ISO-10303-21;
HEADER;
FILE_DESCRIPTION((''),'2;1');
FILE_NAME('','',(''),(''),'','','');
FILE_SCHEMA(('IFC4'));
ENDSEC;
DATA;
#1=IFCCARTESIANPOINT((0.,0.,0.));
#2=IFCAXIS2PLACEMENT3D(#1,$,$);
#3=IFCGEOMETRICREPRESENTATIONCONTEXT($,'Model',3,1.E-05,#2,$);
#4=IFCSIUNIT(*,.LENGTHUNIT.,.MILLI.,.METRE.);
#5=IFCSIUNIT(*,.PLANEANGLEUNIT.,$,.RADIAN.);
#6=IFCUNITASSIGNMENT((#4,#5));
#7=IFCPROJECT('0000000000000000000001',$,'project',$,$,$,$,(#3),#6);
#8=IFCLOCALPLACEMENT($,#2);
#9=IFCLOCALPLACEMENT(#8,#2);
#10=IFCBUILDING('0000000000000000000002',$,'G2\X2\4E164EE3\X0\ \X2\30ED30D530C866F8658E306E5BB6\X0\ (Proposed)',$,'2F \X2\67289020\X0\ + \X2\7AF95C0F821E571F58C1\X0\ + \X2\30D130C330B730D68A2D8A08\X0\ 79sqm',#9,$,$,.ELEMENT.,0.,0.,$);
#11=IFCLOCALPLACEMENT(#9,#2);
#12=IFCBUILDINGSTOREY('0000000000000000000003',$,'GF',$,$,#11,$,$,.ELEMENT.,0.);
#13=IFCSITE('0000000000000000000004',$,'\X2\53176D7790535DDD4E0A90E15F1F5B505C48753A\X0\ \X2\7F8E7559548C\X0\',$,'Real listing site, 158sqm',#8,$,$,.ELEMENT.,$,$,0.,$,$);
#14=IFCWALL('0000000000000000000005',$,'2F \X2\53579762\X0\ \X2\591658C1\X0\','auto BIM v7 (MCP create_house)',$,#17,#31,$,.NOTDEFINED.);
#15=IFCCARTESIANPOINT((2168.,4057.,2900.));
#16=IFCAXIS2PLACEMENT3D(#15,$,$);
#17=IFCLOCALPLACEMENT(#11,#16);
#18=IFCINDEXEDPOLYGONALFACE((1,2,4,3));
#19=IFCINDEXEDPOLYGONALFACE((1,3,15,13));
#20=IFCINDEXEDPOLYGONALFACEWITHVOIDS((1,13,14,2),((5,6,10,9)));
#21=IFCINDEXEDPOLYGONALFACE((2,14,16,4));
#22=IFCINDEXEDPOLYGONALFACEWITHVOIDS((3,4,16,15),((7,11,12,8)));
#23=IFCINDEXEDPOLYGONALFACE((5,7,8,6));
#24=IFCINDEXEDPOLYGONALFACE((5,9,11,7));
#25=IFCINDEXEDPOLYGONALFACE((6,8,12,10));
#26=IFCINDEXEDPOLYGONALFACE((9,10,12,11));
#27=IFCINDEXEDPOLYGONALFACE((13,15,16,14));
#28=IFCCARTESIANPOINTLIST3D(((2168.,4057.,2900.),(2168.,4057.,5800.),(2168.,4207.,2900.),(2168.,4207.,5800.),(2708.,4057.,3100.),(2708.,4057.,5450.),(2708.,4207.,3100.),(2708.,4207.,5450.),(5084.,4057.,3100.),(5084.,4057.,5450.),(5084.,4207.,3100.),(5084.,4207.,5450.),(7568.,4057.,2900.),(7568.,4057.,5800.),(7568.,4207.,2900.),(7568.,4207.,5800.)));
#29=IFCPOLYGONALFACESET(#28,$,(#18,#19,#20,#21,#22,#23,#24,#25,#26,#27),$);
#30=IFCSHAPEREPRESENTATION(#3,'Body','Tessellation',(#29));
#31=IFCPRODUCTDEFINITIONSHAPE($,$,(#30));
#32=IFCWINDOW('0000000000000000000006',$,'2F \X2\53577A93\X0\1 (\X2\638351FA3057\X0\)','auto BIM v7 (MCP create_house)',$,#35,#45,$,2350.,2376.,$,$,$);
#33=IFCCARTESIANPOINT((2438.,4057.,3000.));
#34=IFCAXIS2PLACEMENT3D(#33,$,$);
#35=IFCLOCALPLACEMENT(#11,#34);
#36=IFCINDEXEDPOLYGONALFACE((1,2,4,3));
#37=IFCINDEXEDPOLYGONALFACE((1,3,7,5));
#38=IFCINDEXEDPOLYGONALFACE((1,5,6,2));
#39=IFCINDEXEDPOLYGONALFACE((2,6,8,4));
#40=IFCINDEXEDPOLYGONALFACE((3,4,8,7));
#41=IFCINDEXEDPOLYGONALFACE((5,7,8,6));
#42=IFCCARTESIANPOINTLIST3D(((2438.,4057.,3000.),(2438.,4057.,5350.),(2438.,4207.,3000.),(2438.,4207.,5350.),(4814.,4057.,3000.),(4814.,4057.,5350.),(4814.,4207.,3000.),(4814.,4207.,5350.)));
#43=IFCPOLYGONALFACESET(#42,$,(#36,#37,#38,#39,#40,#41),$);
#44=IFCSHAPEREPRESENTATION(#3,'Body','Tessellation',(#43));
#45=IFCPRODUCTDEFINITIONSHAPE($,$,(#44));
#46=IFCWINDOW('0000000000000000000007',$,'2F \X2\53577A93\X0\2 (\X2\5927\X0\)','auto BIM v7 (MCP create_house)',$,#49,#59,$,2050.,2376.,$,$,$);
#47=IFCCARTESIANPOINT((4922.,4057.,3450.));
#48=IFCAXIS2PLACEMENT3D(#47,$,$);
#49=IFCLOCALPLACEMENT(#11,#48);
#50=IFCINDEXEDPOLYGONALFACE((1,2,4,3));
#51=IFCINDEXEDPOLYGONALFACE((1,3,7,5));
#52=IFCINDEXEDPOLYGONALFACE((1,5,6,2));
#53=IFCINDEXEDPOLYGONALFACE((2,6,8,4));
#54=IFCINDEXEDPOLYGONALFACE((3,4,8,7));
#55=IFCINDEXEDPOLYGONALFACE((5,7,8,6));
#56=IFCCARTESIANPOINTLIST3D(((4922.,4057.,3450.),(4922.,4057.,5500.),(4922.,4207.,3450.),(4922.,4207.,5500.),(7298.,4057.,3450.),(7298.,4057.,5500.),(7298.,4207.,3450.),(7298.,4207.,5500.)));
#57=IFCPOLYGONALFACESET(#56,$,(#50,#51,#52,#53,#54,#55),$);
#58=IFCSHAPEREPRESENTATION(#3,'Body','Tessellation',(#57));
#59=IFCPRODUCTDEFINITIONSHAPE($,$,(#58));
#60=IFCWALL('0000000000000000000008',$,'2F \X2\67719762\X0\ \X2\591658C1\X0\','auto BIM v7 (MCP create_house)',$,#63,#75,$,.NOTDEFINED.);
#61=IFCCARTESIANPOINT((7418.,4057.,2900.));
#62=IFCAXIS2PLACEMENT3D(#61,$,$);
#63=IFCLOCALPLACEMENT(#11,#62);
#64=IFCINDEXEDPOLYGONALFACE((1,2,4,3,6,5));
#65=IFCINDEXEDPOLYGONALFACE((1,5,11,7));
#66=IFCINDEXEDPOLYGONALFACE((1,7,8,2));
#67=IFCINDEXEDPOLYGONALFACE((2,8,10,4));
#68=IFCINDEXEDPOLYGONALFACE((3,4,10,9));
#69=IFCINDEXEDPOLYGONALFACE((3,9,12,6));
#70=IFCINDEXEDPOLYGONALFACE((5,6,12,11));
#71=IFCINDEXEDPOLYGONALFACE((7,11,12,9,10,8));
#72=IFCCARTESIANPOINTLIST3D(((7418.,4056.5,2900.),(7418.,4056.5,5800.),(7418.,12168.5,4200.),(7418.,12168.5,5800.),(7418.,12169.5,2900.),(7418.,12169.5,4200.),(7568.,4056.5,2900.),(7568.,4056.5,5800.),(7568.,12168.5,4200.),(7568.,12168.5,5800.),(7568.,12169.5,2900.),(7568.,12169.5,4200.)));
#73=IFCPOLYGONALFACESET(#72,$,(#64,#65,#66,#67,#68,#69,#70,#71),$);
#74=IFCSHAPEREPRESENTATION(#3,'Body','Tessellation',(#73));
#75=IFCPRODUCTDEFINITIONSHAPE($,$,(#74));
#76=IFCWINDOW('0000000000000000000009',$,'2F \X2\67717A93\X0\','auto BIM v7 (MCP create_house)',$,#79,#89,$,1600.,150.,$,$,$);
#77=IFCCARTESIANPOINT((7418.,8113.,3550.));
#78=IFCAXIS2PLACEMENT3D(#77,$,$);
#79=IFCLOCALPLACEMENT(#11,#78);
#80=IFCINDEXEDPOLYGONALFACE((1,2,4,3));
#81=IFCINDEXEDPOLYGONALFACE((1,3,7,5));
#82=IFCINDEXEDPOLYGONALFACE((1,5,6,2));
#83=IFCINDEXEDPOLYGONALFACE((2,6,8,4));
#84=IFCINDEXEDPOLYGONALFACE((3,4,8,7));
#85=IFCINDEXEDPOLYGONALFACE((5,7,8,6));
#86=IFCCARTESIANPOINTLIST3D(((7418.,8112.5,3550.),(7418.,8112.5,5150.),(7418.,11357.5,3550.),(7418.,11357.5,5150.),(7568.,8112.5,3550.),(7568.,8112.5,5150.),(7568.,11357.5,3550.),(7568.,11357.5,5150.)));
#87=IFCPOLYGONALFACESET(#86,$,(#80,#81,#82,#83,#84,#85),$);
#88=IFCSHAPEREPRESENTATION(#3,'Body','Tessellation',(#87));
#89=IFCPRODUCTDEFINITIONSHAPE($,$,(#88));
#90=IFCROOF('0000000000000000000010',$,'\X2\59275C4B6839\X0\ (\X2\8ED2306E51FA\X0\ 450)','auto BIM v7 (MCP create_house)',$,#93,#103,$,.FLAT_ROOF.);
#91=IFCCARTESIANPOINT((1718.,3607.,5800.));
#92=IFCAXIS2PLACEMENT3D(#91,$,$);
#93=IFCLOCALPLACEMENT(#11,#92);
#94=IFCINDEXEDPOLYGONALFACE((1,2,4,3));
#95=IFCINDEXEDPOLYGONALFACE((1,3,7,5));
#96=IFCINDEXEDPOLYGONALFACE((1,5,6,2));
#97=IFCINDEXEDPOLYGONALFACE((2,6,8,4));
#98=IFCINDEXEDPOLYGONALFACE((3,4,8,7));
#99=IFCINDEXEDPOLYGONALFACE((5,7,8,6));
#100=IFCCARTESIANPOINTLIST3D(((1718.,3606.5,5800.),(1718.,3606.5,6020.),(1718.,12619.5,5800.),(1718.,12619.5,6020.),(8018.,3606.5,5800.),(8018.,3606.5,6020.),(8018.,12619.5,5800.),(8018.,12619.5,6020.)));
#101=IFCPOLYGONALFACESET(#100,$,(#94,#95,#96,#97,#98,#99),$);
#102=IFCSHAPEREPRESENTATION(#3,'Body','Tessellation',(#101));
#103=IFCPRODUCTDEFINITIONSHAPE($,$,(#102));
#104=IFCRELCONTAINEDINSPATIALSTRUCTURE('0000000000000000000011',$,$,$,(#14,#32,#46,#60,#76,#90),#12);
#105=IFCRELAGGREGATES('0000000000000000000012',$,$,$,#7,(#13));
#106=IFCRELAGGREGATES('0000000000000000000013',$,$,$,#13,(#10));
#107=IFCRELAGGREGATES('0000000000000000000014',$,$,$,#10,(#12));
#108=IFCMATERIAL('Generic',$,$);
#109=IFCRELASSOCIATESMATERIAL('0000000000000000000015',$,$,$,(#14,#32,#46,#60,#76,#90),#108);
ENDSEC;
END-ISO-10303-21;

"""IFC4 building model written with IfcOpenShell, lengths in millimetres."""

from ifc_helpers import new_model, si_unit, frame, frame_2d, origin, place, context, project, spatial, rectangle, extrude, material, element, fill, save


model = new_model("IFC4")

# Units and contexts
model_context = context("Model", 3, precision=1e-05, world=origin())
ifc_project = project(units=[si_unit("LENGTHUNIT", "METRE", prefix="MILLI"), si_unit("PLANEANGLEUNIT", "RADIAN")], contexts=[model_context])

# Site, building, storey
site_placement = place(None, origin())
site = spatial("IfcSite", under=ifc_project, at=site_placement, Name="北海道川上郡弟子屈町 美留和", ObjectType="Real listing site, 158sqm", CompositionType="ELEMENT", RefElevation=0.0)
building_placement = place(site_placement, origin())
building = spatial("IfcBuilding", under=site, at=building_placement, Name="G2世代 ロフト書斎の家 (Proposed)", ObjectType="2F 木造 + 竹小舞土壁 + パッシブ設計 79sqm", CompositionType="ELEMENT", ElevationOfRefHeight=0.0, ElevationOfTerrain=0.0)
storey_placement = place(building_placement, origin())
storey = spatial("IfcBuildingStorey", under=building, at=storey_placement, Name="GF", CompositionType="ELEMENT", Elevation=0.0)

# Shared definitions
ifc_material = material(Name="Generic")

# Wall, openings, windows
wall_1_placement = place(storey_placement, frame((2168.0, 4057.0, 2900.0)))
wall_1 = element("IfcWall", 1, at=wall_1_placement, inside=storey, material=ifc_material, Name="2F 南面 外壁", Description="auto BIM v7 (MCP create_house)", PredefinedType="NOTDEFINED", context=model_context, shape_type="SweptSolid", body=[
    extrude(rectangle(XDim=5400.0, YDim=150.0, at=frame_2d((2700.0, 75.0))), frame((2168.0, 4057.0, 2900.0)), (0.0, 0.0, 1.0), 2900.0),
])
opening_1_placement = place(storey_placement, frame((2438.0, 4057.0, 3000.0)))
opening_1 = element("IfcOpeningElement", 2, at=opening_1_placement, cuts=wall_1, PredefinedType="NOTDEFINED", context=model_context, shape_type="SweptSolid", body=[
    extrude(rectangle(XDim=2376.0, YDim=150.0, at=frame_2d((1188.0, 75.0))), frame((2438.0, 4057.0, 3000.0)), (0.0, 0.0, 1.0), 2350.0),
])
opening_2_placement = place(storey_placement, frame((4922.0, 4057.0, 3450.0)))
opening_2 = element("IfcOpeningElement", 3, at=opening_2_placement, cuts=wall_1, PredefinedType="NOTDEFINED", context=model_context, shape_type="SweptSolid", body=[
    extrude(rectangle(XDim=2376.0, YDim=150.0, at=frame_2d((1188.0, 75.0))), frame((4922.0, 4057.0, 3450.0)), (0.0, 0.0, 1.0), 2050.0),
])
window_1_placement = place(storey_placement, frame((2438.0, 4057.0, 3000.0)))
window_1 = element("IfcWindow", 4, at=window_1_placement, inside=storey, material=ifc_material, Name="2F 南窓1 (掃出し)", Description="auto BIM v7 (MCP create_house)", OverallHeight=2350.0, OverallWidth=2376.0, context=model_context, shape_type="SweptSolid", body=[
    extrude(rectangle(XDim=2376.0, YDim=150.0, at=frame_2d((1188.0, 75.0))), frame((2438.0, 4057.0, 3000.0)), (0.0, 0.0, 1.0), 2350.0),
])
fill(opening_1, window_1)
window_2_placement = place(storey_placement, frame((4922.0, 4057.0, 3450.0)))
window_2 = element("IfcWindow", 5, at=window_2_placement, inside=storey, material=ifc_material, Name="2F 南窓2 (大)", Description="auto BIM v7 (MCP create_house)", OverallHeight=2050.0, OverallWidth=2376.0, context=model_context, shape_type="SweptSolid", body=[
    extrude(rectangle(XDim=2376.0, YDim=150.0, at=frame_2d((1188.0, 75.0))), frame((4922.0, 4057.0, 3450.0)), (0.0, 0.0, 1.0), 2050.0),
])
fill(opening_2, window_2)

# Wall, opening, window
wall_2_placement = place(storey_placement, frame((7418.0, 4057.0, 2900.0)))
wall_2 = element("IfcWall", 6, at=wall_2_placement, inside=storey, material=ifc_material, Name="2F 東面 外壁", Description="auto BIM v7 (MCP create_house)", PredefinedType="NOTDEFINED", context=model_context, shape_type="SweptSolid", body=[
    extrude(rectangle(XDim=150.0, YDim=8113.0, at=frame_2d((75.0, 4056.0))), frame((7418.0, 4057.0, 2900.0)), (0.0, 0.0, 1.0), 2900.0),
])
opening_3_placement = place(storey_placement, frame((7418.0, 8113.0, 3550.0)))
opening_3 = element("IfcOpeningElement", 7, at=opening_3_placement, cuts=wall_2, PredefinedType="NOTDEFINED", context=model_context, shape_type="SweptSolid", body=[
    extrude(rectangle(XDim=150.0, YDim=3245.0, at=frame_2d((75.0, 1622.0))), frame((7418.0, 8113.0, 3550.0)), (0.0, 0.0, 1.0), 1600.0),
])
window_3_placement = place(storey_placement, frame((7418.0, 8113.0, 3550.0)))
window_3 = element("IfcWindow", 8, at=window_3_placement, inside=storey, material=ifc_material, Name="2F 東窓", Description="auto BIM v7 (MCP create_house)", OverallHeight=1600.0, OverallWidth=150.0, context=model_context, shape_type="SweptSolid", body=[
    extrude(rectangle(XDim=150.0, YDim=3245.0, at=frame_2d((75.0, 1622.0))), frame((7418.0, 8113.0, 3550.0)), (0.0, 0.0, 1.0), 1600.0),
])
fill(opening_3, window_3)

# Roof
roof_placement = place(storey_placement, frame((1718.0, 3607.0, 5800.0)))
element("IfcRoof", 9, at=roof_placement, inside=storey, material=ifc_material, Name="大屋根 (軒の出 450)", Description="auto BIM v7 (MCP create_house)", PredefinedType="FLAT_ROOF", context=model_context, shape_type="SweptSolid", body=[
    extrude(rectangle(XDim=6300.0, YDim=9013.0, at=frame_2d((3150.0, 4506.0))), frame((1718.0, 3607.0, 5800.0)), (0.0, 0.0, 1.0), 220.0),
])

save(model, "model.ifc")
